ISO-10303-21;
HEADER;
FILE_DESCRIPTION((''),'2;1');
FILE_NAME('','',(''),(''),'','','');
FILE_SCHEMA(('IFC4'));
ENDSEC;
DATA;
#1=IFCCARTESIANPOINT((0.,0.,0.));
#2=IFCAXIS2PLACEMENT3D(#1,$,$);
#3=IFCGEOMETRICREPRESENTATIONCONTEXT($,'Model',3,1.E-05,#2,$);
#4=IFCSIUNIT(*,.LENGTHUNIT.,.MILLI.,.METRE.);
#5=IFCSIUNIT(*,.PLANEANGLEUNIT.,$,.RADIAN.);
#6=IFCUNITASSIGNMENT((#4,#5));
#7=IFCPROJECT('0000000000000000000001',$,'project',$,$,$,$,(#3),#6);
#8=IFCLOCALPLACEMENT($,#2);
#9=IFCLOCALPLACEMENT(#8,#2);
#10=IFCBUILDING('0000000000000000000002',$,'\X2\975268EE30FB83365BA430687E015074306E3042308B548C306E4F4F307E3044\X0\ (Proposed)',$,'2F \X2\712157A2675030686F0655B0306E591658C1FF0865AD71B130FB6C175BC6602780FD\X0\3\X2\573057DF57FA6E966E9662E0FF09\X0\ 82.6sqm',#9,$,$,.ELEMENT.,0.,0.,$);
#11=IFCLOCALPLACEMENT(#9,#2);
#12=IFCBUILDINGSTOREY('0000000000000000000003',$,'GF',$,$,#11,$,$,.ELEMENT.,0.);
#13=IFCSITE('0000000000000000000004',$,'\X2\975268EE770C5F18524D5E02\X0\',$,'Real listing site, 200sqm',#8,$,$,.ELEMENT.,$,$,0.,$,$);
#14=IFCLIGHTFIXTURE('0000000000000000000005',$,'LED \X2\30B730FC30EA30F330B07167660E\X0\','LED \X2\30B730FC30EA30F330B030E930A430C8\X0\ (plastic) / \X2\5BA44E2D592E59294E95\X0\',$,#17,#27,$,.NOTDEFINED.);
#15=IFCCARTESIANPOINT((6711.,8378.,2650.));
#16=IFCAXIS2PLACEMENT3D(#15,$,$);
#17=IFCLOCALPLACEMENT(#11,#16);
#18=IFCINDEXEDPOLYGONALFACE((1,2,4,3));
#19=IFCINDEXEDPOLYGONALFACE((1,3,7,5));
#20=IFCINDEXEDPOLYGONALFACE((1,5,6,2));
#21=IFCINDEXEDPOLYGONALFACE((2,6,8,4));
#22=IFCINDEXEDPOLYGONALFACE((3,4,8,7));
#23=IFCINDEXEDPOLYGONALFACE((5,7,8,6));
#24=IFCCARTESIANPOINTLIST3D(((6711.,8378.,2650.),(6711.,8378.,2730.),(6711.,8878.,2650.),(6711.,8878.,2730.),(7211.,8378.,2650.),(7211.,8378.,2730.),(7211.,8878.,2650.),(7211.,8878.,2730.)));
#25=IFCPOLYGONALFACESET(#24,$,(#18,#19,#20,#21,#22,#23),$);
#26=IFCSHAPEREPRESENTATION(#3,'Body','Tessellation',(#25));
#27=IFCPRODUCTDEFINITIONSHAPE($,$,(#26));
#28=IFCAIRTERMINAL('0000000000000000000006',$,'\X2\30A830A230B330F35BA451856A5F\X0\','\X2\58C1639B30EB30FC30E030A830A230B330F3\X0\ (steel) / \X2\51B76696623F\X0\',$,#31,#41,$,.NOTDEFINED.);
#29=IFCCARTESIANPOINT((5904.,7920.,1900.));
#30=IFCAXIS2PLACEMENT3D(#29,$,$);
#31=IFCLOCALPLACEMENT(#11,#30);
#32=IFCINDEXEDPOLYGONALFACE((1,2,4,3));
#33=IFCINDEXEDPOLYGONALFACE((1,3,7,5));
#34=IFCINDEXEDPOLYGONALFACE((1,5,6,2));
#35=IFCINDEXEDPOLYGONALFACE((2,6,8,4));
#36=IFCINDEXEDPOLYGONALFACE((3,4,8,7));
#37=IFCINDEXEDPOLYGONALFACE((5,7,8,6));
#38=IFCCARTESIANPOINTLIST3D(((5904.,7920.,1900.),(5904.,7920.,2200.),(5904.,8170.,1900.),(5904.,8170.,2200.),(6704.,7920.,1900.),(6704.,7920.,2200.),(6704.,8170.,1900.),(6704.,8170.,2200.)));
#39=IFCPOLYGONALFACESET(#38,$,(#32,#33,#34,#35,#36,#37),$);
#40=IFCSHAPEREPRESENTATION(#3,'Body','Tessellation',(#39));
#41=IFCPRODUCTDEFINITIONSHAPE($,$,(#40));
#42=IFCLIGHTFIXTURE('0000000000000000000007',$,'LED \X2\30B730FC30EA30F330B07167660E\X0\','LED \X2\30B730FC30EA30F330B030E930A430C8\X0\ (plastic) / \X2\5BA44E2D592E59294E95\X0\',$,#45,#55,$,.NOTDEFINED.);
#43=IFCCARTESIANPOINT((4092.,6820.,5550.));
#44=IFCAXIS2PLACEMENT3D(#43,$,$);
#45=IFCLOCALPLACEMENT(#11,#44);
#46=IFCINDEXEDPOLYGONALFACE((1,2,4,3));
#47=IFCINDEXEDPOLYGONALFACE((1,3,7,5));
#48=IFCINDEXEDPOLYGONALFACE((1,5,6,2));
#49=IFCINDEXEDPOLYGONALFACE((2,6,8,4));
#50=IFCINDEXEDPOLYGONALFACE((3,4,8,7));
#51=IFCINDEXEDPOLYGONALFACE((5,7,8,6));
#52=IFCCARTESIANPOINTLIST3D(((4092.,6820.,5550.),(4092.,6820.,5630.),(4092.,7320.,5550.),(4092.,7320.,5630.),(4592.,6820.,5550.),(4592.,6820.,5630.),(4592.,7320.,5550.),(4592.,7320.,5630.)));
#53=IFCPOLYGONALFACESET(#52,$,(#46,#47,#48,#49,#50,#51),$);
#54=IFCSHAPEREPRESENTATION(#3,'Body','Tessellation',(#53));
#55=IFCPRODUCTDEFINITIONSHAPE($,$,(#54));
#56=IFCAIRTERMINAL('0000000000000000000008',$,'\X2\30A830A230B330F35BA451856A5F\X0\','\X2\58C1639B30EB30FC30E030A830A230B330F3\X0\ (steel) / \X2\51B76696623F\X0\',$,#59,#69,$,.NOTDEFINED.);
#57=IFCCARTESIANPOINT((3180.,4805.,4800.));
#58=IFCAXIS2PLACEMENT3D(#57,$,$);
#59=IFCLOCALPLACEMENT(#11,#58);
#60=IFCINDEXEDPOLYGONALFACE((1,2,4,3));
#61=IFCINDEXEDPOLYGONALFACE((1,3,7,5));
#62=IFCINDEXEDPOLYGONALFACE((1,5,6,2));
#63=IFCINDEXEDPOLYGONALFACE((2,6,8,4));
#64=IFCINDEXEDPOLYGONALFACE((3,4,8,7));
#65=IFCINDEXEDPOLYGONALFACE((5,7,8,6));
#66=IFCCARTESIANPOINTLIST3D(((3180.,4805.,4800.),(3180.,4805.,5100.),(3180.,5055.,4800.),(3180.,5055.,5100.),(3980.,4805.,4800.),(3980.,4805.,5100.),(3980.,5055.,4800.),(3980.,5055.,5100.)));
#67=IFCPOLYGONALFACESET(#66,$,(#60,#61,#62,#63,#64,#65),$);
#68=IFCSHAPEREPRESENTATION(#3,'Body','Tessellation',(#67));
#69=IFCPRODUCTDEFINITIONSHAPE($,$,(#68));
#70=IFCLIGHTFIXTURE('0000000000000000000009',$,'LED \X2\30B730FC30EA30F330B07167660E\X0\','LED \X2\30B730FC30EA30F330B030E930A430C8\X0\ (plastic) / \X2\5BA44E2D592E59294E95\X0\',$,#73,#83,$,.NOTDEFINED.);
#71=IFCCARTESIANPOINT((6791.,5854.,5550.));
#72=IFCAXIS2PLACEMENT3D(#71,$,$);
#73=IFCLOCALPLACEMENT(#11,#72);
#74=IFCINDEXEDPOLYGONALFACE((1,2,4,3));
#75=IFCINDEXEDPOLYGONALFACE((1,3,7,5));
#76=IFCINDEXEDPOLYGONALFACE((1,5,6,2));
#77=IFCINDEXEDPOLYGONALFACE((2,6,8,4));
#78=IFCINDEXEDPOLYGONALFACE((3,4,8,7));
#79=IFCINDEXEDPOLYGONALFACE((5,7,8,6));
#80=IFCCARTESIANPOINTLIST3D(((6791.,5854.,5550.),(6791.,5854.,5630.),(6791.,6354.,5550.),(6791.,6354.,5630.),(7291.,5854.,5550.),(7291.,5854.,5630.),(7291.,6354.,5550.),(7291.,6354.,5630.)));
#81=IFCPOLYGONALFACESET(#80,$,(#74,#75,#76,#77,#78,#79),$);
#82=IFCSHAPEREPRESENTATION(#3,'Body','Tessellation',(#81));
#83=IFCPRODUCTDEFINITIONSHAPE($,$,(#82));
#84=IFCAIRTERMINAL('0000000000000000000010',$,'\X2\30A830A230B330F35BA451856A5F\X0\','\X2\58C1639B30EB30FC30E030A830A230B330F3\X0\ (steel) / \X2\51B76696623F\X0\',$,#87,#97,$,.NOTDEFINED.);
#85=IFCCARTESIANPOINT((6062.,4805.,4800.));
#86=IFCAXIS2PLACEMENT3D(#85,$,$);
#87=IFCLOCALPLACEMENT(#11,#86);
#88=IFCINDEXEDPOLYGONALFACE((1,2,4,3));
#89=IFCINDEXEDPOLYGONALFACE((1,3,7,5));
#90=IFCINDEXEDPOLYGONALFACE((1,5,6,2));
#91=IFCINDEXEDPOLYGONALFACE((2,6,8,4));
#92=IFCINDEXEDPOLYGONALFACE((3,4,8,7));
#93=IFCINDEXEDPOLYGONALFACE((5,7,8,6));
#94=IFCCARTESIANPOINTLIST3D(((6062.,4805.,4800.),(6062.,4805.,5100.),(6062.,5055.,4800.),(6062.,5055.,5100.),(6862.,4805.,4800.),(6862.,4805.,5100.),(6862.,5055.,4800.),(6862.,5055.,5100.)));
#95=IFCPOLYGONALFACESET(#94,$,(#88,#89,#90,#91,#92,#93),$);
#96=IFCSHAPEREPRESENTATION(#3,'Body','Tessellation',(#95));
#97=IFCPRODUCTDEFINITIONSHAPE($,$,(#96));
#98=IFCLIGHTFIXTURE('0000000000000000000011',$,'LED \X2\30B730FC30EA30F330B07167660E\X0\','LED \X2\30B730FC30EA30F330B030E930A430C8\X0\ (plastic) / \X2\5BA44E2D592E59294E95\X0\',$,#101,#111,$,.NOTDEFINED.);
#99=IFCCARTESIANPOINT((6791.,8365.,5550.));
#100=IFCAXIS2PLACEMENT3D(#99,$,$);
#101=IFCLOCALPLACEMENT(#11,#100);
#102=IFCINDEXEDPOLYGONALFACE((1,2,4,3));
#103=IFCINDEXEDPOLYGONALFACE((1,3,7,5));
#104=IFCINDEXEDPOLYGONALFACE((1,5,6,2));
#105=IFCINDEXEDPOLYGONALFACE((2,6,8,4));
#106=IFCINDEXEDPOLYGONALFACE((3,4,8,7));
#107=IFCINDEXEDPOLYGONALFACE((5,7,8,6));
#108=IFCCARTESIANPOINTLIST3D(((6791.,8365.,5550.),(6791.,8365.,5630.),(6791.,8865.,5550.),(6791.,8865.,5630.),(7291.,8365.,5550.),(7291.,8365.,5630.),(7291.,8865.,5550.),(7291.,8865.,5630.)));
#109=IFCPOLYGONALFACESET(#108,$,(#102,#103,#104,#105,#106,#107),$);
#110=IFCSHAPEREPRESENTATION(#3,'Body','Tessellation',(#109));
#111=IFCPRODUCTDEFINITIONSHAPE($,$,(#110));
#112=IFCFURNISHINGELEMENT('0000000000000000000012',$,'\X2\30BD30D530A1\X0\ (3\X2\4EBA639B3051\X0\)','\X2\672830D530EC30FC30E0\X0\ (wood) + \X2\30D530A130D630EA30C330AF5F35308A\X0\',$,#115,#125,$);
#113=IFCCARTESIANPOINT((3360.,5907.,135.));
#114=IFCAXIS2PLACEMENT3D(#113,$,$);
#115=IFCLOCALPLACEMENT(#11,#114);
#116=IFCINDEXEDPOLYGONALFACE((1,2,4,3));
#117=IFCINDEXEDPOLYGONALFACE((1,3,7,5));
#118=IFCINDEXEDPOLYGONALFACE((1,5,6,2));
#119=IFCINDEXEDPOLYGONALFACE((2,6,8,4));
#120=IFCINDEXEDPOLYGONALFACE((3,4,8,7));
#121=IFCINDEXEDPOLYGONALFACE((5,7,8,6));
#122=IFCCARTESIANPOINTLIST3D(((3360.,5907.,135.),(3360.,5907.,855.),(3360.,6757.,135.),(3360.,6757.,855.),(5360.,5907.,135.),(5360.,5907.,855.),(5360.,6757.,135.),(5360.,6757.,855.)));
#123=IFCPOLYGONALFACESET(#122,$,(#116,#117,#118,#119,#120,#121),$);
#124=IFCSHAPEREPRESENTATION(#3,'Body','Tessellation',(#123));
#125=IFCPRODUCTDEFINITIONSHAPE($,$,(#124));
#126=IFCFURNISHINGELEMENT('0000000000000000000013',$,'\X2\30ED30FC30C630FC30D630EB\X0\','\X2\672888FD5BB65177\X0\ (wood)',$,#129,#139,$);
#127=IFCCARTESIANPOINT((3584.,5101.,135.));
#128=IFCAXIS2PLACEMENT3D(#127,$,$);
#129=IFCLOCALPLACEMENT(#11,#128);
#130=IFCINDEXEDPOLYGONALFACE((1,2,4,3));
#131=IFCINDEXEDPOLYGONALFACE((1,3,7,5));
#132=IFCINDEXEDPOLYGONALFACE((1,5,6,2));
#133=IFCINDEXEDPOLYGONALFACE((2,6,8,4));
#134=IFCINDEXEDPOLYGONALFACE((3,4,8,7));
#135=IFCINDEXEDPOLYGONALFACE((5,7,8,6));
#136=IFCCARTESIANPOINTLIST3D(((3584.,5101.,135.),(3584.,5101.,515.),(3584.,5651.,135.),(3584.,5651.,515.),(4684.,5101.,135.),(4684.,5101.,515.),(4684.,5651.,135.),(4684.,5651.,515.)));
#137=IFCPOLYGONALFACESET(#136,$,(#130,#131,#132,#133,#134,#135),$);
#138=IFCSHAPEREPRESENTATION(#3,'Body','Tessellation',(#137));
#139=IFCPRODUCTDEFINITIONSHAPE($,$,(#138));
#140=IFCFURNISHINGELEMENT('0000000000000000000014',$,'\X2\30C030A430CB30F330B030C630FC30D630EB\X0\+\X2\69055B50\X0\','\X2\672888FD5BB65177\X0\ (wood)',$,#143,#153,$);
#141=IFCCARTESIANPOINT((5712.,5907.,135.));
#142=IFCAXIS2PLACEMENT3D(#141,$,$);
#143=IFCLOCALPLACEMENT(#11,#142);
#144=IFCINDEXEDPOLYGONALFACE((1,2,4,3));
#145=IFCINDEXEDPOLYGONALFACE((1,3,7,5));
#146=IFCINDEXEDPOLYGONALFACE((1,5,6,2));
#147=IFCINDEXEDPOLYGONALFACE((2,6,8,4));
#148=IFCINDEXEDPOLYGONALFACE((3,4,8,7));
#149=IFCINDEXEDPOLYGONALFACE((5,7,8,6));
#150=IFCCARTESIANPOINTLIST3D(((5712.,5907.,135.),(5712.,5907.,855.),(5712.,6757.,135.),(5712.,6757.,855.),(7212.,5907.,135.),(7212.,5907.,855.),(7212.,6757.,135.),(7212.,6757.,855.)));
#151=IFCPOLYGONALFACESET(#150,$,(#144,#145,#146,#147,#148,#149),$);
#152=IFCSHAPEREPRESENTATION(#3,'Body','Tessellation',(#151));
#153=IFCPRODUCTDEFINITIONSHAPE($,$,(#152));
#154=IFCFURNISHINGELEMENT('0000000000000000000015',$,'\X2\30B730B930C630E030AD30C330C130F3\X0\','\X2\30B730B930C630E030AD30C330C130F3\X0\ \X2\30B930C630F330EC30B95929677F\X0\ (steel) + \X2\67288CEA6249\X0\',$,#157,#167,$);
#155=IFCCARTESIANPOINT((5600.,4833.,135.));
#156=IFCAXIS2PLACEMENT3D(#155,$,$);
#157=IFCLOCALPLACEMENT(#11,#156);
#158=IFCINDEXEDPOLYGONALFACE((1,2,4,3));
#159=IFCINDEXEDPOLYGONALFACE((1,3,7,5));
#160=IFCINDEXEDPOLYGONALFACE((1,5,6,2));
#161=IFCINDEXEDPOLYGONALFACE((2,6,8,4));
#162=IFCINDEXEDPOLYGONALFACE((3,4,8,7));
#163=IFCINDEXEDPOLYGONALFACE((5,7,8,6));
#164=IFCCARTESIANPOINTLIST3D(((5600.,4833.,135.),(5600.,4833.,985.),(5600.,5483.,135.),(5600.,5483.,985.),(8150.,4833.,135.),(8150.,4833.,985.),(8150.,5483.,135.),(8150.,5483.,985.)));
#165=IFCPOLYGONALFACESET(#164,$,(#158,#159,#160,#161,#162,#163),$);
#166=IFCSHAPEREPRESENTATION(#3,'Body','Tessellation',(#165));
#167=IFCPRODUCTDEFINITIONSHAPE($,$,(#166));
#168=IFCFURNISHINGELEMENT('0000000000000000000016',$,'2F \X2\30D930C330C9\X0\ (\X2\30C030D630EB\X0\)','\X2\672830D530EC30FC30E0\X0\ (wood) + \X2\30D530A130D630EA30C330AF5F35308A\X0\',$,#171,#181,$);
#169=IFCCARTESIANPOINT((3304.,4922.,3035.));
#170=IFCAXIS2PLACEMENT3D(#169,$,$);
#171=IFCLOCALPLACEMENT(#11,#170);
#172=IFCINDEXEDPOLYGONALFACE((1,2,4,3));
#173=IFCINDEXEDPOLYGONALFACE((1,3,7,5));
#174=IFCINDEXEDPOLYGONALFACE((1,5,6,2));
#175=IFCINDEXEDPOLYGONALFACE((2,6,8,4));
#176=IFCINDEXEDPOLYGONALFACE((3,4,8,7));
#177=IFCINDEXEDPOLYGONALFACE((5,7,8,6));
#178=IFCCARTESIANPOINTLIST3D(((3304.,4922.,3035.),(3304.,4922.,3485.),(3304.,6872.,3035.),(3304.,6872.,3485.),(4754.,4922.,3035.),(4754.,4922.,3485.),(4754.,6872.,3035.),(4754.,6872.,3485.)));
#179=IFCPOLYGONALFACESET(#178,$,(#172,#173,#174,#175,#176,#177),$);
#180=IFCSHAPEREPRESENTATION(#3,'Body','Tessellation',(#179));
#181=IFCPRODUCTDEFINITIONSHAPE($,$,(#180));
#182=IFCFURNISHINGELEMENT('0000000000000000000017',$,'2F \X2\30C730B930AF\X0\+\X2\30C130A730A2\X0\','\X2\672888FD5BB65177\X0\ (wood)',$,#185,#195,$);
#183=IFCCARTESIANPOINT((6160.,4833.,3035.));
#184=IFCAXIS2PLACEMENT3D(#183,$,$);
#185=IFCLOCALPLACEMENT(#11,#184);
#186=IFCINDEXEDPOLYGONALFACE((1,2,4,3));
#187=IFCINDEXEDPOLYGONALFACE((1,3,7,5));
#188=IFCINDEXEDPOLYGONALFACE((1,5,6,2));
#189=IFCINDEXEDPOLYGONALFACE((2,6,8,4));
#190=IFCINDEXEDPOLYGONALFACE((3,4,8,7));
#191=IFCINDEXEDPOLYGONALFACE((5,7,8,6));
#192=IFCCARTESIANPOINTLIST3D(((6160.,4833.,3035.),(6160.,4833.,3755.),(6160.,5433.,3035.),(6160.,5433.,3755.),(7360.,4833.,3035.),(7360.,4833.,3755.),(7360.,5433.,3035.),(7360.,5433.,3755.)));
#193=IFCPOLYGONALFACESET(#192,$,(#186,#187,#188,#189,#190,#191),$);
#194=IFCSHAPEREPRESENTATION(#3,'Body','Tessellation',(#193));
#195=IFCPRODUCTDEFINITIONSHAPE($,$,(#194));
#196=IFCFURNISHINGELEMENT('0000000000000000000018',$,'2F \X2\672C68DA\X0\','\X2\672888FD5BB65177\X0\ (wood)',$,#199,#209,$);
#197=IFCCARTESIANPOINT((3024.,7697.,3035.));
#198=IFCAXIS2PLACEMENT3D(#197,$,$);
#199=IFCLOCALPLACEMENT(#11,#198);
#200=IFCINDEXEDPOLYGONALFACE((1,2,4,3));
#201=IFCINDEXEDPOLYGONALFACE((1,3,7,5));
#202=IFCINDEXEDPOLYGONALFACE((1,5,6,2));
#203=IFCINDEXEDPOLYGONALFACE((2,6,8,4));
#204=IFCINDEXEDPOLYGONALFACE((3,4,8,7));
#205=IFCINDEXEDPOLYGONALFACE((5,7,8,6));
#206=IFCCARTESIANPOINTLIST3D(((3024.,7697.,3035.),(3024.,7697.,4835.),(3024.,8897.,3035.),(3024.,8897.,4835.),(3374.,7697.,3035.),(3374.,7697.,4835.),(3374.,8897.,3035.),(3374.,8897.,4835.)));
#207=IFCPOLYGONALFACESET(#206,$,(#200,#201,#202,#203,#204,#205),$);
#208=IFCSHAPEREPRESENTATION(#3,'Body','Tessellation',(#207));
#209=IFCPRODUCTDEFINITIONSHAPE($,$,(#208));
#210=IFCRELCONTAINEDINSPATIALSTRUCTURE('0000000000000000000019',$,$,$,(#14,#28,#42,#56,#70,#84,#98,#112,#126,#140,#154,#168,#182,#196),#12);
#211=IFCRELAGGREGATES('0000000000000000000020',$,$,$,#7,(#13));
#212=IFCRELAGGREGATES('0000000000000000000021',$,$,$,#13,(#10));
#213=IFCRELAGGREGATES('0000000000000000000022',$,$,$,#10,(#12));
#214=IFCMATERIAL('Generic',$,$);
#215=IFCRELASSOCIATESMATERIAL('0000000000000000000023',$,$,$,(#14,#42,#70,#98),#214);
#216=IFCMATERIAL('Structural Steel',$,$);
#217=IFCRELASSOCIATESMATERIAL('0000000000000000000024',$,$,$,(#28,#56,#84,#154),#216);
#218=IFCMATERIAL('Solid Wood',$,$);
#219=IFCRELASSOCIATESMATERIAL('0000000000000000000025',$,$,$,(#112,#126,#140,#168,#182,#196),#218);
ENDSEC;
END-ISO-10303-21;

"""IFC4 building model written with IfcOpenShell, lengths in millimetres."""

from ifc_helpers import new_model, si_unit, frame, frame_2d, origin, place, context, project, spatial, rectangle, extrude, material, element, save


model = new_model("IFC4")

# Units and contexts
model_context = context("Model", 3, precision=1e-05, world=origin())
ifc_project = project(units=[si_unit("LENGTHUNIT", "METRE", prefix="MILLI"), si_unit("PLANEANGLEUNIT", "RADIAN")], contexts=[model_context])

# Site, building, storey
site_placement = place(None, origin())
site = spatial("IfcSite", under=ifc_project, at=site_placement, Name="青森県弘前市", ObjectType="Real listing site, 200sqm", CompositionType="ELEMENT", RefElevation=0.0)
building_placement = place(site_placement, origin())
building = spatial("IfcBuilding", under=site, at=building_placement, Name="青森・茶室と縁側のある和の住まい (Proposed)", ObjectType="2F 無垢材と漆喰の外壁（断熱・気密性能3地域基準準拠） 82.6sqm", CompositionType="ELEMENT", ElevationOfRefHeight=0.0, ElevationOfTerrain=0.0)
storey_placement = place(building_placement, origin())
storey = spatial("IfcBuildingStorey", under=building, at=storey_placement, Name="GF", CompositionType="ELEMENT", Elevation=0.0)

# Shared definitions
ifc_material_1 = material(Name="Solid Wood")

# Shared definitions
ifc_material_2 = material(Name="Structural Steel")

# Shared definitions
ifc_material_3 = material(Name="Generic")

# Light fixture
light_fixture_1_placement = place(storey_placement, frame((6711.0, 8378.0, 2650.0)))
element("IfcLightFixture", 1, at=light_fixture_1_placement, inside=storey, material=ifc_material_3, Name="LED シーリング照明", Description="LED シーリングライト (plastic) / 室中央天井", PredefinedType="NOTDEFINED", context=model_context, shape_type="SweptSolid", body=[
    extrude(rectangle(XDim=500.0, YDim=500.0, at=frame_2d((250.0, 250.0))), frame((6711.0, 8378.0, 2650.0)), (0.0, 0.0, 1.0), 80.0),
])

# Air terminal
air_terminal_1_placement = place(storey_placement, frame((5904.0, 7920.0, 1900.0)))
element("IfcAirTerminal", 2, at=air_terminal_1_placement, inside=storey, material=ifc_material_2, Name="エアコン室内機", Description="壁掛ルームエアコン (steel) / 冷暖房", PredefinedType="NOTDEFINED", context=model_context, shape_type="SweptSolid", body=[
    extrude(rectangle(XDim=800.0, YDim=250.0, at=frame_2d((400.0, 125.0))), frame((5904.0, 7920.0, 1900.0)), (0.0, 0.0, 1.0), 300.0),
])

# Light fixture
light_fixture_2_placement = place(storey_placement, frame((4092.0, 6820.0, 5550.0)))
element("IfcLightFixture", 3, at=light_fixture_2_placement, inside=storey, material=ifc_material_3, Name="LED シーリング照明", Description="LED シーリングライト (plastic) / 室中央天井", PredefinedType="NOTDEFINED", context=model_context, shape_type="SweptSolid", body=[
    extrude(rectangle(XDim=500.0, YDim=500.0, at=frame_2d((250.0, 250.0))), frame((4092.0, 6820.0, 5550.0)), (0.0, 0.0, 1.0), 80.0),
])

# Air terminal
air_terminal_2_placement = place(storey_placement, frame((3180.0, 4805.0, 4800.0)))
element("IfcAirTerminal", 4, at=air_terminal_2_placement, inside=storey, material=ifc_material_2, Name="エアコン室内機", Description="壁掛ルームエアコン (steel) / 冷暖房", PredefinedType="NOTDEFINED", context=model_context, shape_type="SweptSolid", body=[
    extrude(rectangle(XDim=800.0, YDim=250.0, at=frame_2d((400.0, 125.0))), frame((3180.0, 4805.0, 4800.0)), (0.0, 0.0, 1.0), 300.0),
])

# Light fixture
light_fixture_3_placement = place(storey_placement, frame((6791.0, 5854.0, 5550.0)))
element("IfcLightFixture", 5, at=light_fixture_3_placement, inside=storey, material=ifc_material_3, Name="LED シーリング照明", Description="LED シーリングライト (plastic) / 室中央天井", PredefinedType="NOTDEFINED", context=model_context, shape_type="SweptSolid", body=[
    extrude(rectangle(XDim=500.0, YDim=500.0, at=frame_2d((250.0, 250.0))), frame((6791.0, 5854.0, 5550.0)), (0.0, 0.0, 1.0), 80.0),
])

# Air terminal
air_terminal_3_placement = place(storey_placement, frame((6062.0, 4805.0, 4800.0)))
element("IfcAirTerminal", 6, at=air_terminal_3_placement, inside=storey, material=ifc_material_2, Name="エアコン室内機", Description="壁掛ルームエアコン (steel) / 冷暖房", PredefinedType="NOTDEFINED", context=model_context, shape_type="SweptSolid", body=[
    extrude(rectangle(XDim=800.0, YDim=250.0, at=frame_2d((400.0, 125.0))), frame((6062.0, 4805.0, 4800.0)), (0.0, 0.0, 1.0), 300.0),
])

# Light fixture
light_fixture_4_placement = place(storey_placement, frame((6791.0, 8365.0, 5550.0)))
element("IfcLightFixture", 7, at=light_fixture_4_placement, inside=storey, material=ifc_material_3, Name="LED シーリング照明", Description="LED シーリングライト (plastic) / 室中央天井", PredefinedType="NOTDEFINED", context=model_context, shape_type="SweptSolid", body=[
    extrude(rectangle(XDim=500.0, YDim=500.0, at=frame_2d((250.0, 250.0))), frame((6791.0, 8365.0, 5550.0)), (0.0, 0.0, 1.0), 80.0),
])

# Furnishing elements
furnishing_1_placement = place(storey_placement, frame((3360.0, 5907.0, 135.0)))
element("IfcFurnishingElement", 8, at=furnishing_1_placement, inside=storey, material=ifc_material_1, Name="ソファ (3人掛け)", Description="木フレーム (wood) + ファブリック張り", context=model_context, shape_type="SweptSolid", body=[
    extrude(rectangle(XDim=2000.0, YDim=850.0, at=frame_2d((1000.0, 425.0))), frame((3360.0, 5907.0, 135.0)), (0.0, 0.0, 1.0), 720.0),
])
furnishing_2_placement = place(storey_placement, frame((3584.0, 5101.0, 135.0)))
element("IfcFurnishingElement", 9, at=furnishing_2_placement, inside=storey, material=ifc_material_1, Name="ローテーブル", Description="木製家具 (wood)", context=model_context, shape_type="SweptSolid", body=[
    extrude(rectangle(XDim=1100.0, YDim=550.0, at=frame_2d((550.0, 275.0))), frame((3584.0, 5101.0, 135.0)), (0.0, 0.0, 1.0), 380.0),
])
furnishing_3_placement = place(storey_placement, frame((5712.0, 5907.0, 135.0)))
element("IfcFurnishingElement", 10, at=furnishing_3_placement, inside=storey, material=ifc_material_1, Name="ダイニングテーブル+椅子", Description="木製家具 (wood)", context=model_context, shape_type="SweptSolid", body=[
    extrude(rectangle(XDim=1500.0, YDim=850.0, at=frame_2d((750.0, 425.0))), frame((5712.0, 5907.0, 135.0)), (0.0, 0.0, 1.0), 720.0),
])
furnishing_4_placement = place(storey_placement, frame((5600.0, 4833.0, 135.0)))
element("IfcFurnishingElement", 11, at=furnishing_4_placement, inside=storey, material=ifc_material_2, Name="システムキッチン", Description="システムキッチン ステンレス天板 (steel) + 木質扉", context=model_context, shape_type="SweptSolid", body=[
    extrude(rectangle(XDim=2550.0, YDim=650.0, at=frame_2d((1275.0, 325.0))), frame((5600.0, 4833.0, 135.0)), (0.0, 0.0, 1.0), 850.0),
])
furnishing_5_placement = place(storey_placement, frame((3304.0, 4922.0, 3035.0)))
element("IfcFurnishingElement", 12, at=furnishing_5_placement, inside=storey, material=ifc_material_1, Name="2F ベッド (ダブル)", Description="木フレーム (wood) + ファブリック張り", context=model_context, shape_type="SweptSolid", body=[
    extrude(rectangle(XDim=1450.0, YDim=1950.0, at=frame_2d((725.0, 975.0))), frame((3304.0, 4922.0, 3035.0)), (0.0, 0.0, 1.0), 450.0),
])
furnishing_6_placement = place(storey_placement, frame((6160.0, 4833.0, 3035.0)))
element("IfcFurnishingElement", 13, at=furnishing_6_placement, inside=storey, material=ifc_material_1, Name="2F デスク+チェア", Description="木製家具 (wood)", context=model_context, shape_type="SweptSolid", body=[
    extrude(rectangle(XDim=1200.0, YDim=600.0, at=frame_2d((600.0, 300.0))), frame((6160.0, 4833.0, 3035.0)), (0.0, 0.0, 1.0), 720.0),
])
furnishing_7_placement = place(storey_placement, frame((3024.0, 7697.0, 3035.0)))
element("IfcFurnishingElement", 14, at=furnishing_7_placement, inside=storey, material=ifc_material_1, Name="2F 本棚", Description="木製家具 (wood)", context=model_context, shape_type="SweptSolid", body=[
    extrude(rectangle(XDim=350.0, YDim=1200.0, at=frame_2d((175.0, 600.0))), frame((3024.0, 7697.0, 3035.0)), (0.0, 0.0, 1.0), 1800.0),
])

save(model, "model.ifc")
